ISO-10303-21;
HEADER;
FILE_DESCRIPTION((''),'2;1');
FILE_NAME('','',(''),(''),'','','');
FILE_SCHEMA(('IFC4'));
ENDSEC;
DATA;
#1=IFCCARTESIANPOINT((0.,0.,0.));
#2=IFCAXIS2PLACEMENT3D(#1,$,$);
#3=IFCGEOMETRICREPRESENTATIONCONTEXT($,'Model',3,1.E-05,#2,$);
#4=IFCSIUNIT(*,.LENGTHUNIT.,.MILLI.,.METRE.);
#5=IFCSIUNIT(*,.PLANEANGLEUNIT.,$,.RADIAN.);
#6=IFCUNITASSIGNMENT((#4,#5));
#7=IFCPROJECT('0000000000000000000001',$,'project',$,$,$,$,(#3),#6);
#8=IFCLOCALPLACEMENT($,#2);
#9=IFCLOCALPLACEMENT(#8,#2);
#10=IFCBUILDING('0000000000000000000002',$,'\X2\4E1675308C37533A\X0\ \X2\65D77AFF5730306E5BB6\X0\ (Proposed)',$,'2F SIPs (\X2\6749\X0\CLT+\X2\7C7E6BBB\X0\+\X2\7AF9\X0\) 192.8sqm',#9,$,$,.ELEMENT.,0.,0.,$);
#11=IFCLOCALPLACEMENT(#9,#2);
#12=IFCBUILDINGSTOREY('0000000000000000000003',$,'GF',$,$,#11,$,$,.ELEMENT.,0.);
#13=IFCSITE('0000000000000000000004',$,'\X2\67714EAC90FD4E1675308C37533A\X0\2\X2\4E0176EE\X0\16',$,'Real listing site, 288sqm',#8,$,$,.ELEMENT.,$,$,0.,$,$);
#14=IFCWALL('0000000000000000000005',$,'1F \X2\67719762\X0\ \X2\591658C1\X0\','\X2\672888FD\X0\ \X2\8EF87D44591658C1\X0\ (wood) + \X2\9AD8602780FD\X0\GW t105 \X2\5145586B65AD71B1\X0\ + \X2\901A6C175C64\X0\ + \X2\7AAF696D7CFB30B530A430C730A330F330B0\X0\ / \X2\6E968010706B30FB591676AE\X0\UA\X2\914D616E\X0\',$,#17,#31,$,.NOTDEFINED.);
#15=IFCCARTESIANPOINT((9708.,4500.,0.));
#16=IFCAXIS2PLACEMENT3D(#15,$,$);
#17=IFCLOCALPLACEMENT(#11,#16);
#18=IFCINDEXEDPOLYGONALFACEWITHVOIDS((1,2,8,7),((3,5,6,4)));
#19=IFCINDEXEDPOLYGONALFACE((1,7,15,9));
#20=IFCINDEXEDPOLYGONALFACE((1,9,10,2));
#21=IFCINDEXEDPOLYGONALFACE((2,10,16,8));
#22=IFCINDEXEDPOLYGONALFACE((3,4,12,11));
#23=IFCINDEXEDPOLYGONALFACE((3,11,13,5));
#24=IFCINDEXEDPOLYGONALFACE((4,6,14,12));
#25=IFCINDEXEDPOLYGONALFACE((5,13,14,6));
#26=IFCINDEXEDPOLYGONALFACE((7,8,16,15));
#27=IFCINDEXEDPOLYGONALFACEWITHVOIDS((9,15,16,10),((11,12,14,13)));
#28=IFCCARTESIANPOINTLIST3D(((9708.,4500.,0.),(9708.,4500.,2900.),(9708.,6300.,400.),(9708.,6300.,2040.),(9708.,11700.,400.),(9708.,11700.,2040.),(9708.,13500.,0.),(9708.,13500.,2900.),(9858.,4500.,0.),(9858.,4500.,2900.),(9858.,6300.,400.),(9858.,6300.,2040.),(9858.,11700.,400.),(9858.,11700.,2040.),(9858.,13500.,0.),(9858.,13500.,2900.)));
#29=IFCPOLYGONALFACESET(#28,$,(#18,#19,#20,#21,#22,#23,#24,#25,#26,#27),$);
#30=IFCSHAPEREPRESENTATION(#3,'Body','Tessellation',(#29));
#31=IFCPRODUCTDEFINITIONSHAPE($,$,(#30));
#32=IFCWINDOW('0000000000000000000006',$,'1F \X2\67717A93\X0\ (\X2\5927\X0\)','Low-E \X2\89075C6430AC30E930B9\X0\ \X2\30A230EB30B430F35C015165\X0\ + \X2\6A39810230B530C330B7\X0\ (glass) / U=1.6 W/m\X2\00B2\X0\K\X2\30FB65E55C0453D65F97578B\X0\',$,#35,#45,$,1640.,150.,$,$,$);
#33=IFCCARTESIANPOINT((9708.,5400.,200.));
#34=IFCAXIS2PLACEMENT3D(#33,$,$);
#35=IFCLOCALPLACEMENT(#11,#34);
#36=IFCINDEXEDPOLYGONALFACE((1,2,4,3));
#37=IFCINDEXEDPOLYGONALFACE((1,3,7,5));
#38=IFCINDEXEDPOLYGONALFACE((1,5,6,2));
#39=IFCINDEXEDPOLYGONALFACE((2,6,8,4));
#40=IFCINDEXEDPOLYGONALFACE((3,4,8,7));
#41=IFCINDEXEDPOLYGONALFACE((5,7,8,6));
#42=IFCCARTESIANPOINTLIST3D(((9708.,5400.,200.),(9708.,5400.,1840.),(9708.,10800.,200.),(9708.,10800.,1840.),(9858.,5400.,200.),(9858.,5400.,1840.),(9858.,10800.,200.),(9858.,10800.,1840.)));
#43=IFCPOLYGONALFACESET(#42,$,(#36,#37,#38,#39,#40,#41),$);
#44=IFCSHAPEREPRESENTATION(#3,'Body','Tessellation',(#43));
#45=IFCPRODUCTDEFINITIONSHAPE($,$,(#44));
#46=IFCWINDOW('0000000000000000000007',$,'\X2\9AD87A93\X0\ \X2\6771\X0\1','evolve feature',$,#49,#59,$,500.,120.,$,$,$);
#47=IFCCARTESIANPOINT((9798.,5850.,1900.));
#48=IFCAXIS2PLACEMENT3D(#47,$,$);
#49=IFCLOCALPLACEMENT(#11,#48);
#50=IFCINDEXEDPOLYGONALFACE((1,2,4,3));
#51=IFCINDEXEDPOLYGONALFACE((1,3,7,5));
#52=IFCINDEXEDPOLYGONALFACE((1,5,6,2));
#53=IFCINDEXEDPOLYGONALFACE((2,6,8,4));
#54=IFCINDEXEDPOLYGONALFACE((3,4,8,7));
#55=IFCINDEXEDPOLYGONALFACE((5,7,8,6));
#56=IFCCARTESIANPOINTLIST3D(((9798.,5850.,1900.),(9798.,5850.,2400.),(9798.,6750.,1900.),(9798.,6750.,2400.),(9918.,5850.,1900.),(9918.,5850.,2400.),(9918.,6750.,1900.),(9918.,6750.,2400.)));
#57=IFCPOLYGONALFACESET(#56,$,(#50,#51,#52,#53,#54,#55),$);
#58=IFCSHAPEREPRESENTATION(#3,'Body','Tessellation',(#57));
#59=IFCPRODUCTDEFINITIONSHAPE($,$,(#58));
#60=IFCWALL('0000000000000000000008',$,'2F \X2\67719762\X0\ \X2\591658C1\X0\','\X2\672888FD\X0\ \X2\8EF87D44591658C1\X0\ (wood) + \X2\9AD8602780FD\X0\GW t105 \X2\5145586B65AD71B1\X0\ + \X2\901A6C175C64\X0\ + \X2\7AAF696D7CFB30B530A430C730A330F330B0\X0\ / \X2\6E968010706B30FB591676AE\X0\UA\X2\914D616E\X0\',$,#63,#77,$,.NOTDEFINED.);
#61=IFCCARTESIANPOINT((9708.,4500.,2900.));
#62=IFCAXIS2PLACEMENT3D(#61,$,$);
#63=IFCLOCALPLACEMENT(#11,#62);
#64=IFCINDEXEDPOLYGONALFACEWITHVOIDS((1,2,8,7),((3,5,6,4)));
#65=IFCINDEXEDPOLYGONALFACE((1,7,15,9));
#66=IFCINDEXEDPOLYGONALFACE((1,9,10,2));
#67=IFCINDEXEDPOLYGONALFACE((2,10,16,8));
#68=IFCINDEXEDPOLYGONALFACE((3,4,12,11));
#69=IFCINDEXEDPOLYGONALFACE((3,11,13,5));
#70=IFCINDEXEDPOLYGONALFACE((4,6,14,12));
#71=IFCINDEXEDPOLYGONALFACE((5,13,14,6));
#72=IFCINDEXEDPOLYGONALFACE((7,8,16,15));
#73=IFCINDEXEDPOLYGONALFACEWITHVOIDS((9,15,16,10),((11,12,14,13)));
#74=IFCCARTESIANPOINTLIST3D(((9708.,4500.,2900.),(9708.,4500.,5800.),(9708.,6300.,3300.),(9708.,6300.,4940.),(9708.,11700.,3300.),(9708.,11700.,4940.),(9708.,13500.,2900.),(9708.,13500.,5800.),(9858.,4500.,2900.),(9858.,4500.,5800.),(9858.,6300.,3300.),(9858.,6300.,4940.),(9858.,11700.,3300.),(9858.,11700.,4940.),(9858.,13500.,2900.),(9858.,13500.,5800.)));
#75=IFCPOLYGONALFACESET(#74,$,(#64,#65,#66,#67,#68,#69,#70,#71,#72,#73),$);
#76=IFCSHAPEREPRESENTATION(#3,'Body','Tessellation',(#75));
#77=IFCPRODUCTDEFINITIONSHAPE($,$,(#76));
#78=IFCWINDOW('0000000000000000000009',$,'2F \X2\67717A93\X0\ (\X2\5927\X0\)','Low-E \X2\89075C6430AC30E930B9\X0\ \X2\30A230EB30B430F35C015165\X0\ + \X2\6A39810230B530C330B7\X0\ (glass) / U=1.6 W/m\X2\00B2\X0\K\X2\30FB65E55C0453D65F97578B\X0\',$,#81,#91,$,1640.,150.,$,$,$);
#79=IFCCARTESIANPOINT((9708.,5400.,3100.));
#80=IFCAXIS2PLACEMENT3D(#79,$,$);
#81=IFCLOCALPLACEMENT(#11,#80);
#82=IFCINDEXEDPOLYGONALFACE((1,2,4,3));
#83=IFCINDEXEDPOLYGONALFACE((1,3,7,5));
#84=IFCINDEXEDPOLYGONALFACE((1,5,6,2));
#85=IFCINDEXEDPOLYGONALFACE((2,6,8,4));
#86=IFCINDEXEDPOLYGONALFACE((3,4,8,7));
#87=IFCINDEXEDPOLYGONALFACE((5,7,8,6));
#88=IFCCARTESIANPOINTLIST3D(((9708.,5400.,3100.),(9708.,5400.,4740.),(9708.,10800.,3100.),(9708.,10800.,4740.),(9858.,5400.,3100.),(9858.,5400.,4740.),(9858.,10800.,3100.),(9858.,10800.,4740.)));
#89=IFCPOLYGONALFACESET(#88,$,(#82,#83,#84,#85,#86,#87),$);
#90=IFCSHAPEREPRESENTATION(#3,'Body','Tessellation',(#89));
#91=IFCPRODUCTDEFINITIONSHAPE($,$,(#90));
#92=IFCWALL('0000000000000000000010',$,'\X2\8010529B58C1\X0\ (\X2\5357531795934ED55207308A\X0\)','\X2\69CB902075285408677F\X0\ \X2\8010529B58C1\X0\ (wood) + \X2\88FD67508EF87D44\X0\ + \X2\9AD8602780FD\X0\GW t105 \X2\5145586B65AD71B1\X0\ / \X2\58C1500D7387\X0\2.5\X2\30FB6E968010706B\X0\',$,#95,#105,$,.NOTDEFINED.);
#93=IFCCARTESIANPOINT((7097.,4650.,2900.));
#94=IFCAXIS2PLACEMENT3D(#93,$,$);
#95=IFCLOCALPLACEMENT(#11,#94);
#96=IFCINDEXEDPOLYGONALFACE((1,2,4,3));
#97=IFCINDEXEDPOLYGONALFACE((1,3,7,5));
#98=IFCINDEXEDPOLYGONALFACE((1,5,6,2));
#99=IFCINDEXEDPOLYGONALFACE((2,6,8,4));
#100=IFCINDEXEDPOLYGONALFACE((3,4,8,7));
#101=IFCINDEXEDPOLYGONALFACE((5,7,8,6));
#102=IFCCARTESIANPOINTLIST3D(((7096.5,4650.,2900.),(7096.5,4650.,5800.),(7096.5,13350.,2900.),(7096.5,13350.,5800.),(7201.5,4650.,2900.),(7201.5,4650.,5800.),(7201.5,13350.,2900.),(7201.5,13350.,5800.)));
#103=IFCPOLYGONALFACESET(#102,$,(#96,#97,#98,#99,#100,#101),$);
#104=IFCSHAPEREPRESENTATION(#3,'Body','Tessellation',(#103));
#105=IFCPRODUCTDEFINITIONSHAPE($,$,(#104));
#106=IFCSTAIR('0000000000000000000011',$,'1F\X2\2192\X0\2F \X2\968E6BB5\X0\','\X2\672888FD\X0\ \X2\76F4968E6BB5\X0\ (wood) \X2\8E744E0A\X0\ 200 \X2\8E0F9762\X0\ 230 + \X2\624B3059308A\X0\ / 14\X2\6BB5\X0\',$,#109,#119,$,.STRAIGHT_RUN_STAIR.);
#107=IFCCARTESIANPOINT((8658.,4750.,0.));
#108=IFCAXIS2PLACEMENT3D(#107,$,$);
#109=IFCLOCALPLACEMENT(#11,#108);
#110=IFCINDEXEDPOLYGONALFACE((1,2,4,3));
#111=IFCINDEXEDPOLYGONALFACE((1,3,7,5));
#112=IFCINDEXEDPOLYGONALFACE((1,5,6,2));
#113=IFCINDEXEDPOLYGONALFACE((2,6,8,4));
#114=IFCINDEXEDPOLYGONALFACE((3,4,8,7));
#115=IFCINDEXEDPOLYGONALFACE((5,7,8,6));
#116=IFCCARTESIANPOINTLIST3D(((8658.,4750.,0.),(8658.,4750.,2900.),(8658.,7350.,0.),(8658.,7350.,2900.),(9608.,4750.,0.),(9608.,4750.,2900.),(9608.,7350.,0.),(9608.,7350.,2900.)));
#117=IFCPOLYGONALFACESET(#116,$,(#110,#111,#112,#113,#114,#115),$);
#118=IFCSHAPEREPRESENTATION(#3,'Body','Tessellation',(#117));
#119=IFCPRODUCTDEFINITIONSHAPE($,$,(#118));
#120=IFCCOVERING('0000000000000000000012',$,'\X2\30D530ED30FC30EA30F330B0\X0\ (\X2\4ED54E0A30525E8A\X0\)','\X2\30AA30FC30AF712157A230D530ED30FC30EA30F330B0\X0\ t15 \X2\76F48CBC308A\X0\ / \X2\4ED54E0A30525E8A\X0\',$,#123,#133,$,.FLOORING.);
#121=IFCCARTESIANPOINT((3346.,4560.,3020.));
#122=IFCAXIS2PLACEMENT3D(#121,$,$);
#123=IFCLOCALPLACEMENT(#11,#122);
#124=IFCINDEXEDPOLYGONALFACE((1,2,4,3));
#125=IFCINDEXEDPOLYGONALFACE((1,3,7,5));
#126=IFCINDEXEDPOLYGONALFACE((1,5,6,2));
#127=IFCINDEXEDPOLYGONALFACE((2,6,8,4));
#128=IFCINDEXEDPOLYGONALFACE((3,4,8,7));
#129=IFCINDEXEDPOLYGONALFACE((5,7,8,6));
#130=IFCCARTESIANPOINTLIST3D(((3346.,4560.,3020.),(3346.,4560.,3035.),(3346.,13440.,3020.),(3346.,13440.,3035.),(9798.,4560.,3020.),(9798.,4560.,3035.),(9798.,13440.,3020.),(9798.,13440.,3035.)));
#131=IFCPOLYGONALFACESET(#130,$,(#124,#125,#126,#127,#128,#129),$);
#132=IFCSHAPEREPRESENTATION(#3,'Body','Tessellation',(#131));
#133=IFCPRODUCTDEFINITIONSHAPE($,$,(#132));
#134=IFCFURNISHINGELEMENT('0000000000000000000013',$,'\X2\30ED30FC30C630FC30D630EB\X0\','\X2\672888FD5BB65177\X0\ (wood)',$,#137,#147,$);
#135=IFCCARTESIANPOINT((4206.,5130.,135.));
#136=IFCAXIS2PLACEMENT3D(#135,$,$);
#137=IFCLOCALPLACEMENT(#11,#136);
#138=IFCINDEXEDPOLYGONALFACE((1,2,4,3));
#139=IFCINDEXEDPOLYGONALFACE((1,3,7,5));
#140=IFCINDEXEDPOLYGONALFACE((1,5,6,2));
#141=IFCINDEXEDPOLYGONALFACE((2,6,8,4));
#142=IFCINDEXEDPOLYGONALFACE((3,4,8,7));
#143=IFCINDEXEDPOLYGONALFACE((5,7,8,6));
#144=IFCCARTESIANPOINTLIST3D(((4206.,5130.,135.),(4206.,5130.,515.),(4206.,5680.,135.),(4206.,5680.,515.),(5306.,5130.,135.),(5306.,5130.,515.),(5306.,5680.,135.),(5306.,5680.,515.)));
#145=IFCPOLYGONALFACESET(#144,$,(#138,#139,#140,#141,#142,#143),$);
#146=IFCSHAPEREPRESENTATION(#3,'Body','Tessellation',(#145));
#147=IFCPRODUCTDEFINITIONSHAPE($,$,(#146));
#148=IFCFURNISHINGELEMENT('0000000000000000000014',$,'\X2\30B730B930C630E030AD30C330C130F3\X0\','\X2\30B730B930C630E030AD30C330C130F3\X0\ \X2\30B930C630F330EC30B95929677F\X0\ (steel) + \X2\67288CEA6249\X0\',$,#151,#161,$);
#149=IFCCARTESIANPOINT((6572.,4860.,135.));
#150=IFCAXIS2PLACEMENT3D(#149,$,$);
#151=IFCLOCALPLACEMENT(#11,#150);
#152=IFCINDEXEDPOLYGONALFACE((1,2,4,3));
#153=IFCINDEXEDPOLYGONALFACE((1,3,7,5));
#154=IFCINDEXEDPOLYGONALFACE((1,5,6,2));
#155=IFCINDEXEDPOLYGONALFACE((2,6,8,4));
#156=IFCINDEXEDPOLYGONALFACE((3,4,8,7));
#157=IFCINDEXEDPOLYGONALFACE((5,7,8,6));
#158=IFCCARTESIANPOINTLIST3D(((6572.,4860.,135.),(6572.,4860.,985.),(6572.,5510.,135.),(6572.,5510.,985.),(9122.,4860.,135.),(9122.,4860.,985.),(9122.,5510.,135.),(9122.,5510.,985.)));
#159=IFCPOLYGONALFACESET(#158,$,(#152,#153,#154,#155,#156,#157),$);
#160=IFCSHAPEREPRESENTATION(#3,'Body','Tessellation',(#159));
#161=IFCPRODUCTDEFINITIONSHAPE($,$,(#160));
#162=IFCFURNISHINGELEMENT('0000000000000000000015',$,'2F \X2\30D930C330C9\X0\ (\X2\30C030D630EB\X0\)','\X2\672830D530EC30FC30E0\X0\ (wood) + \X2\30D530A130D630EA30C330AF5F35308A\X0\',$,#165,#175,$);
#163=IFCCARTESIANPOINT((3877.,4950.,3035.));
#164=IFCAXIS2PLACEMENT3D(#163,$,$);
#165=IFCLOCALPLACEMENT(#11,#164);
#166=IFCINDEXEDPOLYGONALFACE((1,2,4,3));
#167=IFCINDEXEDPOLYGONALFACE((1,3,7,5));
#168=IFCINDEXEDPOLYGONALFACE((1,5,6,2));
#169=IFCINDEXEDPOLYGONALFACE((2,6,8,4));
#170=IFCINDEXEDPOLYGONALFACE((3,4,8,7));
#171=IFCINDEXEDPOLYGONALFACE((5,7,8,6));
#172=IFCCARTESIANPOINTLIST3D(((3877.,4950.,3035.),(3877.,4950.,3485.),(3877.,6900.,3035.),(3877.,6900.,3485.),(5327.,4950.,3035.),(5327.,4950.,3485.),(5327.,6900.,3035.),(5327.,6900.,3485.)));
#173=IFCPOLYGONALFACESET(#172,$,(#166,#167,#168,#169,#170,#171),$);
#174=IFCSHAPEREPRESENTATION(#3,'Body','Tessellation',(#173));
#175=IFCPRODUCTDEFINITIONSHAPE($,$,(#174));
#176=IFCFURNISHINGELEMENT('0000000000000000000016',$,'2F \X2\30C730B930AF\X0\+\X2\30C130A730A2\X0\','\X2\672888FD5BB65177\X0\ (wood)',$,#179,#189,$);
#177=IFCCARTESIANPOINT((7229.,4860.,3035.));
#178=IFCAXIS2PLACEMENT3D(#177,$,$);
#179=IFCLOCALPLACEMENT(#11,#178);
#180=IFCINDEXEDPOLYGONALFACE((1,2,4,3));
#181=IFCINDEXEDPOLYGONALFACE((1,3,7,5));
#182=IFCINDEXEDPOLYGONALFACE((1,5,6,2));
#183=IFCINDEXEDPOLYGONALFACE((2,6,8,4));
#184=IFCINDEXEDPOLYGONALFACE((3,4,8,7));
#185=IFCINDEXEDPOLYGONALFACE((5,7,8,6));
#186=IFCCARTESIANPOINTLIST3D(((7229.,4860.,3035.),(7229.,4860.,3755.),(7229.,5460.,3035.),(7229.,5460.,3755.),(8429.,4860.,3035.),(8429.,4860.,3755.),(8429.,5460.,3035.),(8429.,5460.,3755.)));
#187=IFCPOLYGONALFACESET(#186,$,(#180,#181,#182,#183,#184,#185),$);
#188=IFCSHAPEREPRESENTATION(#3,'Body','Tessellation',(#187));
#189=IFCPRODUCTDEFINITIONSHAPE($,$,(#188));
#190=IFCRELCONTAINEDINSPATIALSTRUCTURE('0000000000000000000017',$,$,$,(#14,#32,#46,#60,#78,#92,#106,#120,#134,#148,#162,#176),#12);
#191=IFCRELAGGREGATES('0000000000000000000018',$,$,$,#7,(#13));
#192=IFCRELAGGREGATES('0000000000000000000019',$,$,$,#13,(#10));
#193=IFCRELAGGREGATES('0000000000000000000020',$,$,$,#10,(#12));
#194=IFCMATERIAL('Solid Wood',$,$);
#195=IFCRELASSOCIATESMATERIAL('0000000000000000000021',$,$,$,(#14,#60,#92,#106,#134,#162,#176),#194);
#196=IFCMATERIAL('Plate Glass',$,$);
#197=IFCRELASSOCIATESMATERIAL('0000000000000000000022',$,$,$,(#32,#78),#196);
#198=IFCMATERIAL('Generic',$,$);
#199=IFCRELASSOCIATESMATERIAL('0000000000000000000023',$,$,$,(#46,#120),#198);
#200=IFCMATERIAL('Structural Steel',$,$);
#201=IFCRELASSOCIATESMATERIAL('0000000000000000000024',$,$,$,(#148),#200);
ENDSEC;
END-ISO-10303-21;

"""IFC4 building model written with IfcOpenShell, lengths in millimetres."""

from ifc_helpers import new_model, si_unit, frame, frame_2d, origin, place, context, project, spatial, rectangle, extrude, material, element, fill, save


model = new_model("IFC4")

# Units and contexts
model_context = context("Model", 3, precision=1e-05, world=origin())
ifc_project = project(units=[si_unit("LENGTHUNIT", "METRE", prefix="MILLI"), si_unit("PLANEANGLEUNIT", "RADIAN")], contexts=[model_context])

# Site, building, storey
site_placement = place(None, origin())
site = spatial("IfcSite", under=ifc_project, at=site_placement, Name="東京都世田谷区2丁目16", ObjectType="Real listing site, 288sqm", CompositionType="ELEMENT", RefElevation=0.0)
building_placement = place(site_placement, origin())
building = spatial("IfcBuilding", under=site, at=building_placement, Name="世田谷区 旗竿地の家 (Proposed)", ObjectType="2F SIPs (杉CLT+籾殻+竹) 192.8sqm", CompositionType="ELEMENT", ElevationOfRefHeight=0.0, ElevationOfTerrain=0.0)
storey_placement = place(building_placement, origin())
storey = spatial("IfcBuildingStorey", under=building, at=storey_placement, Name="GF", CompositionType="ELEMENT", Elevation=0.0)

# Shared definitions
ifc_material_1 = material(Name="Solid Wood")

# Wall, openings, windows
wall_1_placement = place(storey_placement, frame((9708.0, 4500.0, 0.0)))
wall_1 = element("IfcWall", 1, at=wall_1_placement, inside=storey, material=ifc_material_1, Name="1F 東面 外壁", Description="木製 軸組外壁 (wood) + 高性能GW t105 充填断熱 + 通気層 + 窯業系サイディング / 準耐火・外皮UA配慮", PredefinedType="NOTDEFINED", context=model_context, shape_type="SweptSolid", body=[
    extrude(rectangle(XDim=150.0, YDim=9000.0, at=frame_2d((75.0, 4500.0))), frame((9708.0, 4500.0, 0.0)), (0.0, 0.0, 1.0), 2900.0),
])
opening_1_placement = place(storey_placement, frame((9708.0, 5400.0, 200.0)))
opening_1 = element("IfcOpeningElement", 2, at=opening_1_placement, cuts=wall_1, PredefinedType="NOTDEFINED", context=model_context, shape_type="SweptSolid", body=[
    extrude(rectangle(XDim=150.0, YDim=5400.0, at=frame_2d((75.0, 2700.0))), frame((9708.0, 5400.0, 200.0)), (0.0, 0.0, 1.0), 1640.0),
])
opening_2_placement = place(storey_placement, frame((9798.0, 5850.0, 1900.0)))
opening_2 = element("IfcOpeningElement", 3, at=opening_2_placement, cuts=wall_1, PredefinedType="NOTDEFINED", context=model_context, shape_type="SweptSolid", body=[
    extrude(rectangle(XDim=120.0, YDim=900.0, at=frame_2d((60.0, 450.0))), frame((9798.0, 5850.0, 1900.0)), (0.0, 0.0, 1.0), 500.0),
])
ifc_material_2 = material(Name="Plate Glass")
window_1_placement = place(storey_placement, frame((9708.0, 5400.0, 200.0)))
window_1 = element("IfcWindow", 4, at=window_1_placement, inside=storey, material=ifc_material_2, Name="1F 東窓 (大)", Description="Low-E 複層ガラス アルゴン封入 + 樹脂サッシ (glass) / U=1.6 W/m²K・日射取得型", OverallHeight=1640.0, OverallWidth=150.0, context=model_context, shape_type="SweptSolid", body=[
    extrude(rectangle(XDim=150.0, YDim=5400.0, at=frame_2d((75.0, 2700.0))), frame((9708.0, 5400.0, 200.0)), (0.0, 0.0, 1.0), 1640.0),
])
fill(opening_1, window_1)
ifc_material_3 = material(Name="Generic")
window_2_placement = place(storey_placement, frame((9798.0, 5850.0, 1900.0)))
window_2 = element("IfcWindow", 5, at=window_2_placement, inside=storey, material=ifc_material_3, Name="高窓 東1", Description="evolve feature", OverallHeight=500.0, OverallWidth=120.0, context=model_context, shape_type="SweptSolid", body=[
    extrude(rectangle(XDim=120.0, YDim=900.0, at=frame_2d((60.0, 450.0))), frame((9798.0, 5850.0, 1900.0)), (0.0, 0.0, 1.0), 500.0),
])
fill(opening_2, window_2)

# Wall, opening, window
wall_2_placement = place(storey_placement, frame((9708.0, 4500.0, 2900.0)))
wall_2 = element("IfcWall", 6, at=wall_2_placement, inside=storey, material=ifc_material_1, Name="2F 東面 外壁", Description="木製 軸組外壁 (wood) + 高性能GW t105 充填断熱 + 通気層 + 窯業系サイディング / 準耐火・外皮UA配慮", PredefinedType="NOTDEFINED", context=model_context, shape_type="SweptSolid", body=[
    extrude(rectangle(XDim=150.0, YDim=9000.0, at=frame_2d((75.0, 4500.0))), frame((9708.0, 4500.0, 2900.0)), (0.0, 0.0, 1.0), 2900.0),
])
opening_3_placement = place(storey_placement, frame((9708.0, 5400.0, 3100.0)))
opening_3 = element("IfcOpeningElement", 7, at=opening_3_placement, cuts=wall_2, PredefinedType="NOTDEFINED", context=model_context, shape_type="SweptSolid", body=[
    extrude(rectangle(XDim=150.0, YDim=5400.0, at=frame_2d((75.0, 2700.0))), frame((9708.0, 5400.0, 3100.0)), (0.0, 0.0, 1.0), 1640.0),
])
window_3_placement = place(storey_placement, frame((9708.0, 5400.0, 3100.0)))
window_3 = element("IfcWindow", 8, at=window_3_placement, inside=storey, material=ifc_material_2, Name="2F 東窓 (大)", Description="Low-E 複層ガラス アルゴン封入 + 樹脂サッシ (glass) / U=1.6 W/m²K・日射取得型", OverallHeight=1640.0, OverallWidth=150.0, context=model_context, shape_type="SweptSolid", body=[
    extrude(rectangle(XDim=150.0, YDim=5400.0, at=frame_2d((75.0, 2700.0))), frame((9708.0, 5400.0, 3100.0)), (0.0, 0.0, 1.0), 1640.0),
])
fill(opening_3, window_3)

# Wall
wall_3_placement = place(storey_placement, frame((7097.0, 4650.0, 2900.0)))
element("IfcWall", 9, at=wall_3_placement, inside=storey, material=ifc_material_1, Name="耐力壁 (南北間仕切り)", Description="構造用合板 耐力壁 (wood) + 製材軸組 + 高性能GW t105 充填断熱 / 壁倍率2.5・準耐火", PredefinedType="NOTDEFINED", context=model_context, shape_type="SweptSolid", body=[
    extrude(rectangle(XDim=105.0, YDim=8700.0, at=frame_2d((52.0, 4350.0))), frame((7097.0, 4650.0, 2900.0)), (0.0, 0.0, 1.0), 2900.0),
])

# Stair
stair_placement = place(storey_placement, frame((8658.0, 4750.0, 0.0)))
element("IfcStair", 10, at=stair_placement, inside=storey, material=ifc_material_1, Name="1F→2F 階段", Description="木製 直階段 (wood) 蹴上 200 踏面 230 + 手すり / 14段", PredefinedType="STRAIGHT_RUN_STAIR", context=model_context, shape_type="SweptSolid", body=[
    extrude(rectangle(XDim=950.0, YDim=2600.0, at=frame_2d((475.0, 1300.0))), frame((8658.0, 4750.0, 0.0)), (0.0, 0.0, 1.0), 2900.0),
])

# Covering
covering_placement = place(storey_placement, frame((3346.0, 4560.0, 3020.0)))
element("IfcCovering", 11, at=covering_placement, inside=storey, material=ifc_material_3, Name="フローリング (仕上げ床)", Description="オーク無垢フローリング t15 直貼り / 仕上げ床", PredefinedType="FLOORING", context=model_context, shape_type="SweptSolid", body=[
    extrude(rectangle(XDim=6452.0, YDim=8880.0, at=frame_2d((3226.0, 4440.0))), frame((3346.0, 4560.0, 3020.0)), (0.0, 0.0, 1.0), 15.0),
])

# Furnishing elements
furnishing_1_placement = place(storey_placement, frame((4206.0, 5130.0, 135.0)))
element("IfcFurnishingElement", 12, at=furnishing_1_placement, inside=storey, material=ifc_material_1, Name="ローテーブル", Description="木製家具 (wood)", context=model_context, shape_type="SweptSolid", body=[
    extrude(rectangle(XDim=1100.0, YDim=550.0, at=frame_2d((550.0, 275.0))), frame((4206.0, 5130.0, 135.0)), (0.0, 0.0, 1.0), 380.0),
])
ifc_material_4 = material(Name="Structural Steel")
furnishing_2_placement = place(storey_placement, frame((6572.0, 4860.0, 135.0)))
element("IfcFurnishingElement", 13, at=furnishing_2_placement, inside=storey, material=ifc_material_4, Name="システムキッチン", Description="システムキッチン ステンレス天板 (steel) + 木質扉", context=model_context, shape_type="SweptSolid", body=[
    extrude(rectangle(XDim=2550.0, YDim=650.0, at=frame_2d((1275.0, 325.0))), frame((6572.0, 4860.0, 135.0)), (0.0, 0.0, 1.0), 850.0),
])
furnishing_3_placement = place(storey_placement, frame((3877.0, 4950.0, 3035.0)))
element("IfcFurnishingElement", 14, at=furnishing_3_placement, inside=storey, material=ifc_material_1, Name="2F ベッド (ダブル)", Description="木フレーム (wood) + ファブリック張り", context=model_context, shape_type="SweptSolid", body=[
    extrude(rectangle(XDim=1450.0, YDim=1950.0, at=frame_2d((725.0, 975.0))), frame((3877.0, 4950.0, 3035.0)), (0.0, 0.0, 1.0), 450.0),
])
furnishing_4_placement = place(storey_placement, frame((7229.0, 4860.0, 3035.0)))
element("IfcFurnishingElement", 15, at=furnishing_4_placement, inside=storey, material=ifc_material_1, Name="2F デスク+チェア", Description="木製家具 (wood)", context=model_context, shape_type="SweptSolid", body=[
    extrude(rectangle(XDim=1200.0, YDim=600.0, at=frame_2d((600.0, 300.0))), frame((7229.0, 4860.0, 3035.0)), (0.0, 0.0, 1.0), 720.0),
])

save(model, "model.ifc")
